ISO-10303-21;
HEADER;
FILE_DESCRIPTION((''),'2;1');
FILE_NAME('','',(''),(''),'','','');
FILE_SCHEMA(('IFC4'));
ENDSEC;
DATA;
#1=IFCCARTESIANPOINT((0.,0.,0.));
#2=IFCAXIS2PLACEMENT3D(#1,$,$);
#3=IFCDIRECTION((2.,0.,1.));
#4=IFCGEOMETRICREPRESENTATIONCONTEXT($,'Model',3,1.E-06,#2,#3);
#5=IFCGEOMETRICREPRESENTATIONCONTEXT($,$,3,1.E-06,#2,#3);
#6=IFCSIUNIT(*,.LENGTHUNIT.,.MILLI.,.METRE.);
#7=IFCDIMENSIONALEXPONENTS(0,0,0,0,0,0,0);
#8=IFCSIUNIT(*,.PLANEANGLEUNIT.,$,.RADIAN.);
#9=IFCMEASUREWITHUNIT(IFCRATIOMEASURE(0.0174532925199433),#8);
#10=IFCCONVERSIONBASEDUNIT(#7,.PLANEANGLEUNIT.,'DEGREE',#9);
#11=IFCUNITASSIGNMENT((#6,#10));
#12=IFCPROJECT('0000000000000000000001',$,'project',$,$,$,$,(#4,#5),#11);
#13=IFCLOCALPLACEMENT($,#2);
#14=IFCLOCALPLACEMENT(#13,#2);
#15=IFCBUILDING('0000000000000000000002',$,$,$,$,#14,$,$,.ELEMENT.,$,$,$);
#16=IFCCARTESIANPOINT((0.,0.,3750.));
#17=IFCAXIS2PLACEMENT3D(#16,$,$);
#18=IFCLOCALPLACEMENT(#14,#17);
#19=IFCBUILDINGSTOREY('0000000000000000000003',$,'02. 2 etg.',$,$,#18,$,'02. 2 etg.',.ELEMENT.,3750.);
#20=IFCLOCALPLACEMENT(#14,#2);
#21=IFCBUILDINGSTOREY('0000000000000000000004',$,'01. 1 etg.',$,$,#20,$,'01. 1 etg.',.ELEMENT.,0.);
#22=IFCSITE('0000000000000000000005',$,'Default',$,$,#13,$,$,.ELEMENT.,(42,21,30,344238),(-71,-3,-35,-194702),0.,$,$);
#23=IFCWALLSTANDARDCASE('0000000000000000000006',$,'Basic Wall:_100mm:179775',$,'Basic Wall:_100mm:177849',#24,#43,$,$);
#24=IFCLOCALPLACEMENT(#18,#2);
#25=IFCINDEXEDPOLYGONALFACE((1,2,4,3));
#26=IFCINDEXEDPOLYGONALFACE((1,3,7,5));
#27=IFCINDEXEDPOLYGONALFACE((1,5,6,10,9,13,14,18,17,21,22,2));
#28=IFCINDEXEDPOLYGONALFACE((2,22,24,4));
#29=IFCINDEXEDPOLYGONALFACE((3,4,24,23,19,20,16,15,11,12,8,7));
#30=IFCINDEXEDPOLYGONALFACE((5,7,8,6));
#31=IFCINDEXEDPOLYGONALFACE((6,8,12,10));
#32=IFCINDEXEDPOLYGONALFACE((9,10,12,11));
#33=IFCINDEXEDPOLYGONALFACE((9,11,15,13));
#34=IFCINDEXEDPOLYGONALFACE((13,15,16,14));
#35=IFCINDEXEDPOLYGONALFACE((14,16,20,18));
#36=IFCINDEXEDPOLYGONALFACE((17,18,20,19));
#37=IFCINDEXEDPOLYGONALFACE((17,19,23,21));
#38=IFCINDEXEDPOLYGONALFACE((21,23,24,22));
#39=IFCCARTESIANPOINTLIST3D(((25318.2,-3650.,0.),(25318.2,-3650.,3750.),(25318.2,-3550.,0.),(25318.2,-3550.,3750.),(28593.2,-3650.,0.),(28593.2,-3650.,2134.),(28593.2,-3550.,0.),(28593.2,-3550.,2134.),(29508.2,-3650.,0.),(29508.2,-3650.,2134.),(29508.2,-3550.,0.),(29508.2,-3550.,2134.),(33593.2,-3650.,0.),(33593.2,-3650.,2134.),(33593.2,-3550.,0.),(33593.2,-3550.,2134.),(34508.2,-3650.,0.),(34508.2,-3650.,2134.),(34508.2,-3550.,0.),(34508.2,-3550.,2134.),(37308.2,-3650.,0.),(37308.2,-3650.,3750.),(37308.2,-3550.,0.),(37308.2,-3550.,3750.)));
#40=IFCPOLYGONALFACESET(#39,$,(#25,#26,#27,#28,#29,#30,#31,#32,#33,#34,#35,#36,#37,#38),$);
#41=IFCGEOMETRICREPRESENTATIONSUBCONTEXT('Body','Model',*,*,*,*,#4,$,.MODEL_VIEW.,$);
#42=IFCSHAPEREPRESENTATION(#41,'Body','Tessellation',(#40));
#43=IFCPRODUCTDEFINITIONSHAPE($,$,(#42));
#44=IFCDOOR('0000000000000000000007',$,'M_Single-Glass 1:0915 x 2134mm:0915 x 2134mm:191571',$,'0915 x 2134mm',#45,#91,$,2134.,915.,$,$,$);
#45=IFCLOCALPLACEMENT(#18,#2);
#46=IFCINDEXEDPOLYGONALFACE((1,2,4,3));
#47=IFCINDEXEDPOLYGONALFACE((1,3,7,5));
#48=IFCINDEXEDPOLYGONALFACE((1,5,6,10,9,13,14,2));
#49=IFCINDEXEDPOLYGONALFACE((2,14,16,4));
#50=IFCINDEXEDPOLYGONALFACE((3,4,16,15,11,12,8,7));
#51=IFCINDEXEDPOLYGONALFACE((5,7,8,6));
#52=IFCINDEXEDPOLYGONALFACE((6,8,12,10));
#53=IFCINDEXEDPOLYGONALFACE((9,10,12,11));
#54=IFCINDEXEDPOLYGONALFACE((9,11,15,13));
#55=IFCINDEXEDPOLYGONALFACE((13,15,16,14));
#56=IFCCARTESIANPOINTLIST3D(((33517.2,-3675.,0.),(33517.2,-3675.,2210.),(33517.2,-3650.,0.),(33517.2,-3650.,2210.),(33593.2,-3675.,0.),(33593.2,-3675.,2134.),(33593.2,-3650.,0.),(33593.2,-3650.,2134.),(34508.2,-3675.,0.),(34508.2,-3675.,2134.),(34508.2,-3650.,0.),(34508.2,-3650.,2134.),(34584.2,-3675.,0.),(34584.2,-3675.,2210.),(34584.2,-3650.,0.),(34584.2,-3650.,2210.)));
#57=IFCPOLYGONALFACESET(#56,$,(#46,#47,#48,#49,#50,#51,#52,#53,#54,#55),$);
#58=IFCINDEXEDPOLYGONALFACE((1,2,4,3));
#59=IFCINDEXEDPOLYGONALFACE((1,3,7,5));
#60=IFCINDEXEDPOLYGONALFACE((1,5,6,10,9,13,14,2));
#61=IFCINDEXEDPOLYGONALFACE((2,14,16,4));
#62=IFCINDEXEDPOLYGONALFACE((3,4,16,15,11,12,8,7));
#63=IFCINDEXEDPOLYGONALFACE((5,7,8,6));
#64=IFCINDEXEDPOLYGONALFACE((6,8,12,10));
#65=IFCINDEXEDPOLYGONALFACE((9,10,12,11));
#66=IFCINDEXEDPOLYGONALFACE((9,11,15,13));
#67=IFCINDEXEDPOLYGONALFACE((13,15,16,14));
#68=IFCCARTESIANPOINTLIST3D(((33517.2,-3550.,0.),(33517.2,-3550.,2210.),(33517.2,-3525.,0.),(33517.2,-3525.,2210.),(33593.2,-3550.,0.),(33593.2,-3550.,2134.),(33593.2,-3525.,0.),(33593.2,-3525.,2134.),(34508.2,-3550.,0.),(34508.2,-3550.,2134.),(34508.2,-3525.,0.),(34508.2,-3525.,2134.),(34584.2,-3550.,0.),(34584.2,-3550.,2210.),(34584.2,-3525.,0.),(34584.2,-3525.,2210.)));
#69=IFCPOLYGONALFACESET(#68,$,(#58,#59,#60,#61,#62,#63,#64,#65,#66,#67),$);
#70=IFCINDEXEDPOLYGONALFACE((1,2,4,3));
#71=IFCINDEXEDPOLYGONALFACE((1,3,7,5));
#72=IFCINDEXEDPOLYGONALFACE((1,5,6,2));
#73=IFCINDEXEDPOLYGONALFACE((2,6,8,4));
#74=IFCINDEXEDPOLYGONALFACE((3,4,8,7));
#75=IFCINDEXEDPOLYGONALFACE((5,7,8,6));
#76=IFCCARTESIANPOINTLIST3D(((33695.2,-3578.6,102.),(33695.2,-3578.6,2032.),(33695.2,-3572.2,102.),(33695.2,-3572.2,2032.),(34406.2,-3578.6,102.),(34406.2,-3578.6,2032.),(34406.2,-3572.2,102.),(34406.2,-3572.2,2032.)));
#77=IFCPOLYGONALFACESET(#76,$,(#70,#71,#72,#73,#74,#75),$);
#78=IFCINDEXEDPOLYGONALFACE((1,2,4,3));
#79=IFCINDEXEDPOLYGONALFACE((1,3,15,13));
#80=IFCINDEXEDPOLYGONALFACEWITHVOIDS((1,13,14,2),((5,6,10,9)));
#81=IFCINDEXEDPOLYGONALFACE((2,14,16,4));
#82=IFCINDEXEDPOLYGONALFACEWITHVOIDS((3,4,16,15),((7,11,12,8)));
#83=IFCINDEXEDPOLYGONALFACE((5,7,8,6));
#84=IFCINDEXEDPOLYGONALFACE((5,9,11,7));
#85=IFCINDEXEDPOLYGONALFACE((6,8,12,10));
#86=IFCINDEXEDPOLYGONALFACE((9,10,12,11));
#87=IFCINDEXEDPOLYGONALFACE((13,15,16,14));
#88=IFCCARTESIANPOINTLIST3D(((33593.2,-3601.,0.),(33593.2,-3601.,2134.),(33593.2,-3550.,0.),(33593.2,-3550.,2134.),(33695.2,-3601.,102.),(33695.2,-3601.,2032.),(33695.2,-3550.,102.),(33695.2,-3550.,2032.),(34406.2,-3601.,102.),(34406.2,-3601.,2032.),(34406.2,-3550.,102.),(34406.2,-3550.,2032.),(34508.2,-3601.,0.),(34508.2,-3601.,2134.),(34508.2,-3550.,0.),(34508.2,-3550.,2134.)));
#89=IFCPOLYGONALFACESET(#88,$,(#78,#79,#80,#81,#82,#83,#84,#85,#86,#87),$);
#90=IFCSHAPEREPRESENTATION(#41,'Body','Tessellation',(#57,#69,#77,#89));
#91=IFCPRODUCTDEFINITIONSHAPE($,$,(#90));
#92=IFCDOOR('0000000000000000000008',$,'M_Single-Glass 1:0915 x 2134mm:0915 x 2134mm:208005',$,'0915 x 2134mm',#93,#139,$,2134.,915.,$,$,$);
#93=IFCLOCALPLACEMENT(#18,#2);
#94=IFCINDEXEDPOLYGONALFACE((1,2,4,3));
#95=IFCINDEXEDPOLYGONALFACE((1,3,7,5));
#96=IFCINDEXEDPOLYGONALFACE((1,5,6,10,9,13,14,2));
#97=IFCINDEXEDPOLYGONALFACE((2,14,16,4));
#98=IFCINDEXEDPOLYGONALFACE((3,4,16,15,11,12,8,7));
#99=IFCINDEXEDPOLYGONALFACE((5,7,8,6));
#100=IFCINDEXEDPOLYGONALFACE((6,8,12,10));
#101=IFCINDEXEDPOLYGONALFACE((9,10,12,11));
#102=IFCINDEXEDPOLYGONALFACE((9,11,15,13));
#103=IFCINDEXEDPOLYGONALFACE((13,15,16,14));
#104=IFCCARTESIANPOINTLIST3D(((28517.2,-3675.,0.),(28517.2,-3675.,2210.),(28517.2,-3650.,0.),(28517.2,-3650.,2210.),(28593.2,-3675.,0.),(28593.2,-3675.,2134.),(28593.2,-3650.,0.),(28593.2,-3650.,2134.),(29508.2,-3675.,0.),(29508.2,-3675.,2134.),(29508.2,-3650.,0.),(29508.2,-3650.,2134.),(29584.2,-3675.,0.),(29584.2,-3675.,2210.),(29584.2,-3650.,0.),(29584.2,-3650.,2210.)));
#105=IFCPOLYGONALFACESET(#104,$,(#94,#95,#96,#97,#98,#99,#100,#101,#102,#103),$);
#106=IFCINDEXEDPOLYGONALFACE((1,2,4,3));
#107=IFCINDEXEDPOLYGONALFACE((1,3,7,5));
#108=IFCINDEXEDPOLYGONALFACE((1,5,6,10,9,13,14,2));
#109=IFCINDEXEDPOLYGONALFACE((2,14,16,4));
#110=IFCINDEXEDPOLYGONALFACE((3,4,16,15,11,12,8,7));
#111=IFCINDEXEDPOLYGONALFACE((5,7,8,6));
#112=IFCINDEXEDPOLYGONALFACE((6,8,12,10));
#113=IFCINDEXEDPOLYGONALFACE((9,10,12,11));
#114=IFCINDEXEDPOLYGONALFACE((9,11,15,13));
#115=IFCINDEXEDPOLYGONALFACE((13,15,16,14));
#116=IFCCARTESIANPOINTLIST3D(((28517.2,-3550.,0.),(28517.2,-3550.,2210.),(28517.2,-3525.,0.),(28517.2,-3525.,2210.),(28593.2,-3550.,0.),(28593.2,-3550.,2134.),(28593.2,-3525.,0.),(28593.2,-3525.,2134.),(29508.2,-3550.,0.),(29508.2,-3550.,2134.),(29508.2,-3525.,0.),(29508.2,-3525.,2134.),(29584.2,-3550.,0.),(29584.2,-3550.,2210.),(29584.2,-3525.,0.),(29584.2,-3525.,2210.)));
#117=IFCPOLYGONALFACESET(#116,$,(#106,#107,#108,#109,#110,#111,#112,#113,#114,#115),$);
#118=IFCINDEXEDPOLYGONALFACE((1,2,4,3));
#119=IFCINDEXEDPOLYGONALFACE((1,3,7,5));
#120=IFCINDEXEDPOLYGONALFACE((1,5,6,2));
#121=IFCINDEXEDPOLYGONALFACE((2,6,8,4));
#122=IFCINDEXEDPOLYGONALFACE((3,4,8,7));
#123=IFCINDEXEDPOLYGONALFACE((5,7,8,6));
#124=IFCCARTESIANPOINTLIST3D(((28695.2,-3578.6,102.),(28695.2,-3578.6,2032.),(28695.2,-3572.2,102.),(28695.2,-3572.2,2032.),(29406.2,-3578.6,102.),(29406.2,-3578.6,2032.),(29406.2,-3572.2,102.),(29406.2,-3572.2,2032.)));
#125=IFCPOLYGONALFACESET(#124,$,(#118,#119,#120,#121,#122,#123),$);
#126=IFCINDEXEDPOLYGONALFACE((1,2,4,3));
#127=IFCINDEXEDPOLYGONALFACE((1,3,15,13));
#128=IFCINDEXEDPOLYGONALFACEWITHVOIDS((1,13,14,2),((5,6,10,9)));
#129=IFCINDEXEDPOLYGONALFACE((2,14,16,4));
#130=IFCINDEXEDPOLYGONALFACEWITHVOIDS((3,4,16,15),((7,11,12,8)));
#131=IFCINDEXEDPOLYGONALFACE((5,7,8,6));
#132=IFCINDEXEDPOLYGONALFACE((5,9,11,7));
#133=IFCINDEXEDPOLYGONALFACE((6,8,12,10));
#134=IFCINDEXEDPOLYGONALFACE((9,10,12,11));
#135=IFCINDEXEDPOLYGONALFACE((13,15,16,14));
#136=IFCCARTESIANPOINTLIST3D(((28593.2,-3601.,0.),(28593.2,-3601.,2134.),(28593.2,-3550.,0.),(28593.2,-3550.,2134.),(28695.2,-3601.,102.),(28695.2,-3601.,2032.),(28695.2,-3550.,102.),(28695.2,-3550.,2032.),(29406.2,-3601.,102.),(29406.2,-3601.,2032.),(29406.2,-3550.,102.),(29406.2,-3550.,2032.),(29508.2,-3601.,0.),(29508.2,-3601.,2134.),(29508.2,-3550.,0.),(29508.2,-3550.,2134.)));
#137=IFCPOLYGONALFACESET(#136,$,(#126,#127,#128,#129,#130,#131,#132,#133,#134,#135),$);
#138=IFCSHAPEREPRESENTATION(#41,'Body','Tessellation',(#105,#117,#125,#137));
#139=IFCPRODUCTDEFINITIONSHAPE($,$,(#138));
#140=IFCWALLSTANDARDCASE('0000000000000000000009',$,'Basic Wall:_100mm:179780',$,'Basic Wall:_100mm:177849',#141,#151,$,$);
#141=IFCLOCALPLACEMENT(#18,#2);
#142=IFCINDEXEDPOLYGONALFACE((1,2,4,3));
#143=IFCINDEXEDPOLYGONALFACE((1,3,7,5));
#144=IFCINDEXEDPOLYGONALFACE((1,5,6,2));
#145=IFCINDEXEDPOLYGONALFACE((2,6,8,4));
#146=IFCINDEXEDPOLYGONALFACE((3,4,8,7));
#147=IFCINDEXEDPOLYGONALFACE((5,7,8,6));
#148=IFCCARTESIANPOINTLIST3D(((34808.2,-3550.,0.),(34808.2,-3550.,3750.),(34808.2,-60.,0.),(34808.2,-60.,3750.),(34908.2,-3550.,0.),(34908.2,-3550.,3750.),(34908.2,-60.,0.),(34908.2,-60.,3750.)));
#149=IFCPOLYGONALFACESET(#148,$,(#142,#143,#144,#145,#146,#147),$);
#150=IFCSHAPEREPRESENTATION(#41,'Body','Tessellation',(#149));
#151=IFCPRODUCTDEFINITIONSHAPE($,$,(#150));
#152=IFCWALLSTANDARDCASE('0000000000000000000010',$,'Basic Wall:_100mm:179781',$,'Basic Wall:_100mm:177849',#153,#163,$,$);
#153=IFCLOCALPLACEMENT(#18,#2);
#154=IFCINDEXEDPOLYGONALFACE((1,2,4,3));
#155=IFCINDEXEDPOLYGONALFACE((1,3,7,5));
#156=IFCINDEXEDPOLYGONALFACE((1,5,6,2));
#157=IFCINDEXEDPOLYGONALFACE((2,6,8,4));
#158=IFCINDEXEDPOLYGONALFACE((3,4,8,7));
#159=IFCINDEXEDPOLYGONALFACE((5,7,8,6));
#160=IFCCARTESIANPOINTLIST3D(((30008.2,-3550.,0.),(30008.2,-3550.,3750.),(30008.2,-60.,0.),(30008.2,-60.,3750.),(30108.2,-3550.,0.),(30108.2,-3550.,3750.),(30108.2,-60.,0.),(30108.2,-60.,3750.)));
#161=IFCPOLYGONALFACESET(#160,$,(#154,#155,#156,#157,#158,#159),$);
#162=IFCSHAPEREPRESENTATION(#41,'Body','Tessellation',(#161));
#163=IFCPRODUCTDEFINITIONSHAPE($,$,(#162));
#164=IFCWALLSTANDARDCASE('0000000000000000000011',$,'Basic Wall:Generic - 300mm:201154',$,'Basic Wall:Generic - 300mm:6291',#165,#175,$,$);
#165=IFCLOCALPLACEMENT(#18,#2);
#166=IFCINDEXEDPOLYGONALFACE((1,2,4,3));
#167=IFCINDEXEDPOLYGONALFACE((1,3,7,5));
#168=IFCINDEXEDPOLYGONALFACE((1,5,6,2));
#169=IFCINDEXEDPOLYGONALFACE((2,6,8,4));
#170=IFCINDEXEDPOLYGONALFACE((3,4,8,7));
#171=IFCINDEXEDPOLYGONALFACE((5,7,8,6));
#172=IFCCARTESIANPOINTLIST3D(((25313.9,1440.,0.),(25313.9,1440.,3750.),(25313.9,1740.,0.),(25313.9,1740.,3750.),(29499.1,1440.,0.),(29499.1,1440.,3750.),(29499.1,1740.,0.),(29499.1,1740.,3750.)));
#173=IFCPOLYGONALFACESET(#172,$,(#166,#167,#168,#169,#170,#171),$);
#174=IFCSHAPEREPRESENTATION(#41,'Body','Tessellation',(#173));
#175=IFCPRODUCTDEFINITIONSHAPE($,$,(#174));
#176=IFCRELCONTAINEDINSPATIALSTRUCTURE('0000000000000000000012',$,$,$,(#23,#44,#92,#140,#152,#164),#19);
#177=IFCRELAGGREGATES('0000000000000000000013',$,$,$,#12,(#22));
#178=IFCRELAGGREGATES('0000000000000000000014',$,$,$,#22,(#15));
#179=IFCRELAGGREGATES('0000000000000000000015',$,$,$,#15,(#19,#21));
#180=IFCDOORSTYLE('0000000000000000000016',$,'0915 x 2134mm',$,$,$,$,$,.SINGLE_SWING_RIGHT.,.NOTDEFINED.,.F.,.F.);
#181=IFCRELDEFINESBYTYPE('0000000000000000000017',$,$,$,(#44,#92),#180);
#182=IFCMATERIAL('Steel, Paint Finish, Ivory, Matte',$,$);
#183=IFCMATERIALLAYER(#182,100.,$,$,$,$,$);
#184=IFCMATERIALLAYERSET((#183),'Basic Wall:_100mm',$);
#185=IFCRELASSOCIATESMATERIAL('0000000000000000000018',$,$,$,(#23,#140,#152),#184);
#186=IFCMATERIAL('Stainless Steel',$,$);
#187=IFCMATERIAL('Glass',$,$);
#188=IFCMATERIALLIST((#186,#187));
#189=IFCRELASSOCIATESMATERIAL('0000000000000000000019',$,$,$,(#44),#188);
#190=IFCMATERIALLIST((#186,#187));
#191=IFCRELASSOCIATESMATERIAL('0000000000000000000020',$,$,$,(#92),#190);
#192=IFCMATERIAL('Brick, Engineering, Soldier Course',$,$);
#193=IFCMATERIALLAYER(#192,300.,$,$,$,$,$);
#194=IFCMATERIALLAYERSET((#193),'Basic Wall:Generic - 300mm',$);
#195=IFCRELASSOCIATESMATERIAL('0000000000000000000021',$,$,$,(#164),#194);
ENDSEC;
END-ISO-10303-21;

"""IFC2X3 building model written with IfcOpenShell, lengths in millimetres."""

from ifc_helpers import new_model, entity, si_unit, converted_unit, direction, frame, frame_2d, origin, place, context, subcontext, project, spatial, polyline, rectangle, outline, extrude, source, transform, mapped, material, material_list, layer, layer_set, layer_usage, type_object, type_shapes, element, fill, save


model = new_model("IFC2X3")

# Units and contexts
model_context = context("Model", 3, precision=1e-06, world=origin(), true_north=direction((2.0, 0.0, 1.0)))
context_of_model = context(None, 3, precision=1e-06, world=origin(), true_north=direction((2.0, 0.0, 1.0)))
body_context = subcontext(model_context, "Body", "Model", "MODEL_VIEW")
ifc_project = project(units=[si_unit("LENGTHUNIT", "METRE", prefix="MILLI"), converted_unit("PLANEANGLEUNIT", "DEGREE", entity("IfcRatioMeasure", 0.0174532925199433), si_unit("PLANEANGLEUNIT", "RADIAN"), dimensions=[0, 0, 0, 0, 0, 0, 0])], contexts=[model_context, context_of_model])

# Site, building, storey
site_placement = place(None, origin())
site = spatial("IfcSite", under=ifc_project, at=site_placement, Name="Default", CompositionType="ELEMENT", RefLatitude=(42, 21, 30, 344238), RefLongitude=(-71, -3, -35, -194702), RefElevation=0.0)
building_placement = place(site_placement, origin())
building = spatial("IfcBuilding", under=site, at=building_placement, CompositionType="ELEMENT")
storey_1_placement = place(building_placement, frame((0.0, 0.0, 3750.0)))
storey_1 = spatial("IfcBuildingStorey", under=building, at=storey_1_placement, Name="02. 2 etg.", LongName="02. 2 etg.", CompositionType="ELEMENT", Elevation=3750.0)

# Shared definitions
ifc_material_1 = material(Name="Glass")
storey_2_placement = place(building_placement, origin())

# Wall, openings, doors
ifc_material_2 = material(Name="Steel, Paint Finish, Ivory, Matte")
ifc_layer_1 = layer(ifc_material_2, 100.0)
ifc_layer_set_1 = layer_set([ifc_layer_1], Name="Basic Wall:_100mm")
ifc_layer_usage_1 = layer_usage(ifc_layer_set_1, "AXIS2", "POSITIVE", -50.0)
wall_1_placement = place(storey_1_placement, frame((25318.2, -3600.0, 0.0)))
wall_1 = element("IfcWallStandardCase", 1, at=wall_1_placement, inside=storey_1, material=ifc_layer_usage_1, Name="Basic Wall:_100mm:179775", ObjectType="Basic Wall:_100mm:177849", context=body_context, shape_type="SweptSolid", body=[
    extrude(rectangle(XDim=11990.0, YDim=100.0, at=frame_2d((5995.0, 0.0), x_axis=(-1.0, 0.0))), origin(), (0.0, 0.0, 1.0), 3750.0),
])
opening_1_placement = place(wall_1_placement, frame((8275.0, -50.0, 0.0)))
opening_1 = element("IfcOpeningElement", 2, at=opening_1_placement, cuts=wall_1, ObjectType="Opening", context=body_context, shape_type="SweptSolid", body=[
    extrude(rectangle(XDim=915.0, YDim=2134.0, at=frame_2d((1067.0, 457.5), x_axis=(0.0, 1.0))), frame((0.0, 0.0, 0.0), z_axis=(0.0, 1.0, 0.0), x_axis=(0.0, 0.0, 1.0)), (0.0, 0.0, 1.0), 100.0),
])
opening_2_placement = place(wall_1_placement, frame((3275.0, -50.0, 0.0)))
opening_2 = element("IfcOpeningElement", 3, at=opening_2_placement, cuts=wall_1, ObjectType="Opening", context=body_context, shape_type="SweptSolid", body=[
    extrude(rectangle(XDim=915.0, YDim=2134.0, at=frame_2d((1067.0, 457.5), x_axis=(0.0, 1.0))), frame((0.0, 0.0, 0.0), z_axis=(0.0, 1.0, 0.0), x_axis=(0.0, 0.0, 1.0)), (0.0, 0.0, 1.0), 100.0),
])
ifc_material_3 = material(Name="Stainless Steel")
ifc_material_list_1 = material_list([ifc_material_3, ifc_material_1])
door_style = type_object("IfcDoorStyle", Name="0915 x 2134mm", ConstructionType="NOTDEFINED", OperationType="SINGLE_SWING_RIGHT", ParameterTakesPrecedence=False, Sizeable=False)
shared_shape_1 = source(origin(), body_context, "Body", "SweptSolid", [
    extrude(outline(polyline([(-457.5, -1048.0), (-457.5, 1086.0), (-533.5, 1086.0), (-533.5, -1124.0), (533.5, -1124.0), (533.5, 1086.0), (457.5, 1086.0), (457.5, -1048.0), (-457.5, -1048.0)])), frame((457.5, -25.0, 1086.0), z_axis=(0.0, -1.0, 0.0), x_axis=(-1.0, 0.0, 0.0)), (0.0, 0.0, -1.0), 25.0),
    extrude(outline(polyline([(-457.5, -1048.0), (-457.5, 1086.0), (-533.5, 1086.0), (-533.5, -1124.0), (533.5, -1124.0), (533.5, 1086.0), (457.5, 1086.0), (457.5, -1048.0), (-457.5, -1048.0)])), frame((457.5, 100.0, 1086.0), z_axis=(0.0, -1.0, 0.0), x_axis=(-1.0, 0.0, 0.0)), (0.0, 0.0, -1.0), 25.0),
    extrude(rectangle(XDim=6.3, YDim=711.0, at=frame_2d((0.0, 0.0), x_axis=(1.0, 0.0))), frame((457.5, 74.6, 102.0), z_axis=(0.0, 0.0, 1.0), x_axis=(0.0, 1.0, 0.0)), (0.0, 0.0, 1.0), 1930.0),
    extrude(outline(polyline([(-1067.0, -457.5), (1067.0, -457.5), (1067.0, 457.5), (-1067.0, 457.5), (-1067.0, -457.5)]), holes=[polyline([(-965.0, 355.5), (965.0, 355.5), (965.0, -355.5), (-965.0, -355.5), (-965.0, 355.5)])]), frame((457.5, 49.0, 1067.0), z_axis=(0.0, 1.0, 0.0), x_axis=(0.0, 0.0, -1.0)), (0.0, 0.0, 1.0), 51.0),
])
type_shapes(door_style, [shared_shape_1])
door_1_placement = place(opening_1_placement, origin())
door_1 = element("IfcDoor", 4, at=door_1_placement, inside=storey_1, type_object=door_style, material=ifc_material_list_1, Name="M_Single-Glass 1:0915 x 2134mm:0915 x 2134mm:191571", ObjectType="0915 x 2134mm", OverallHeight=2134.0, OverallWidth=915.0, context=body_context, shape_type="MappedRepresentation", body=[
    mapped(shared_shape_1, transform((0.0, 0.0, 0.0), scale=1.0)),
])
fill(opening_1, door_1)
ifc_material_list_2 = material_list([ifc_material_3, ifc_material_1])
door_2_placement = place(opening_2_placement, origin())
door_2 = element("IfcDoor", 5, at=door_2_placement, inside=storey_1, type_object=door_style, material=ifc_material_list_2, Name="M_Single-Glass 1:0915 x 2134mm:0915 x 2134mm:208005", ObjectType="0915 x 2134mm", OverallHeight=2134.0, OverallWidth=915.0, context=body_context, shape_type="MappedRepresentation", body=[
    mapped(shared_shape_1, transform((0.0, 0.0, 0.0), scale=1.0)),
])
fill(opening_2, door_2)

# Walls
ifc_layer_usage_2 = layer_usage(ifc_layer_set_1, "AXIS2", "POSITIVE", -50.0)
wall_2_placement = place(storey_1_placement, frame((34858.2, -3550.0, 0.0), z_axis=(0.0, 0.0, 1.0), x_axis=(0.0, 1.0, 0.0)))
element("IfcWallStandardCase", 6, at=wall_2_placement, inside=storey_1, material=ifc_layer_usage_2, Name="Basic Wall:_100mm:179780", ObjectType="Basic Wall:_100mm:177849", context=body_context, shape_type="SweptSolid", body=[
    extrude(rectangle(XDim=3490.0, YDim=100.0, at=frame_2d((1745.0, 0.0), x_axis=(-1.0, 0.0))), origin(), (0.0, 0.0, 1.0), 3750.0),
])
ifc_layer_usage_3 = layer_usage(ifc_layer_set_1, "AXIS2", "POSITIVE", -50.0)
wall_3_placement = place(storey_1_placement, frame((30058.2, -3550.0, 0.0), z_axis=(0.0, 0.0, 1.0), x_axis=(0.0, 1.0, 0.0)))
element("IfcWallStandardCase", 7, at=wall_3_placement, inside=storey_1, material=ifc_layer_usage_3, Name="Basic Wall:_100mm:179781", ObjectType="Basic Wall:_100mm:177849", context=body_context, shape_type="SweptSolid", body=[
    extrude(rectangle(XDim=3490.0, YDim=100.0, at=frame_2d((1745.0, 0.0), x_axis=(-1.0, 0.0))), origin(), (0.0, 0.0, 1.0), 3750.0),
])
ifc_material_4 = material(Name="Brick, Engineering, Soldier Course")
ifc_layer_2 = layer(ifc_material_4, 300.0)
ifc_layer_set_2 = layer_set([ifc_layer_2], Name="Basic Wall:Generic - 300mm")
ifc_layer_usage_4 = layer_usage(ifc_layer_set_2, "AXIS2", "NEGATIVE", 150.0)
wall_4_placement = place(storey_1_placement, frame((29499.1, 1590.0, 0.0), z_axis=(0.0, 0.0, 1.0), x_axis=(-1.0, 0.0, 0.0)))
element("IfcWallStandardCase", 8, at=wall_4_placement, inside=storey_1, material=ifc_layer_usage_4, Name="Basic Wall:Generic - 300mm:201154", ObjectType="Basic Wall:Generic - 300mm:6291", context=body_context, shape_type="SweptSolid", body=[
    extrude(rectangle(XDim=4185.2, YDim=300.0, at=frame_2d((2092.6, 0.0), x_axis=(-1.0, 0.0))), origin(), (0.0, 0.0, 1.0), 3750.0),
])

# Shared definitions
storey_2 = spatial("IfcBuildingStorey", under=building, at=storey_2_placement, Name="01. 1 etg.", LongName="01. 1 etg.", CompositionType="ELEMENT", Elevation=0.0)

save(model, "model.ifc")
